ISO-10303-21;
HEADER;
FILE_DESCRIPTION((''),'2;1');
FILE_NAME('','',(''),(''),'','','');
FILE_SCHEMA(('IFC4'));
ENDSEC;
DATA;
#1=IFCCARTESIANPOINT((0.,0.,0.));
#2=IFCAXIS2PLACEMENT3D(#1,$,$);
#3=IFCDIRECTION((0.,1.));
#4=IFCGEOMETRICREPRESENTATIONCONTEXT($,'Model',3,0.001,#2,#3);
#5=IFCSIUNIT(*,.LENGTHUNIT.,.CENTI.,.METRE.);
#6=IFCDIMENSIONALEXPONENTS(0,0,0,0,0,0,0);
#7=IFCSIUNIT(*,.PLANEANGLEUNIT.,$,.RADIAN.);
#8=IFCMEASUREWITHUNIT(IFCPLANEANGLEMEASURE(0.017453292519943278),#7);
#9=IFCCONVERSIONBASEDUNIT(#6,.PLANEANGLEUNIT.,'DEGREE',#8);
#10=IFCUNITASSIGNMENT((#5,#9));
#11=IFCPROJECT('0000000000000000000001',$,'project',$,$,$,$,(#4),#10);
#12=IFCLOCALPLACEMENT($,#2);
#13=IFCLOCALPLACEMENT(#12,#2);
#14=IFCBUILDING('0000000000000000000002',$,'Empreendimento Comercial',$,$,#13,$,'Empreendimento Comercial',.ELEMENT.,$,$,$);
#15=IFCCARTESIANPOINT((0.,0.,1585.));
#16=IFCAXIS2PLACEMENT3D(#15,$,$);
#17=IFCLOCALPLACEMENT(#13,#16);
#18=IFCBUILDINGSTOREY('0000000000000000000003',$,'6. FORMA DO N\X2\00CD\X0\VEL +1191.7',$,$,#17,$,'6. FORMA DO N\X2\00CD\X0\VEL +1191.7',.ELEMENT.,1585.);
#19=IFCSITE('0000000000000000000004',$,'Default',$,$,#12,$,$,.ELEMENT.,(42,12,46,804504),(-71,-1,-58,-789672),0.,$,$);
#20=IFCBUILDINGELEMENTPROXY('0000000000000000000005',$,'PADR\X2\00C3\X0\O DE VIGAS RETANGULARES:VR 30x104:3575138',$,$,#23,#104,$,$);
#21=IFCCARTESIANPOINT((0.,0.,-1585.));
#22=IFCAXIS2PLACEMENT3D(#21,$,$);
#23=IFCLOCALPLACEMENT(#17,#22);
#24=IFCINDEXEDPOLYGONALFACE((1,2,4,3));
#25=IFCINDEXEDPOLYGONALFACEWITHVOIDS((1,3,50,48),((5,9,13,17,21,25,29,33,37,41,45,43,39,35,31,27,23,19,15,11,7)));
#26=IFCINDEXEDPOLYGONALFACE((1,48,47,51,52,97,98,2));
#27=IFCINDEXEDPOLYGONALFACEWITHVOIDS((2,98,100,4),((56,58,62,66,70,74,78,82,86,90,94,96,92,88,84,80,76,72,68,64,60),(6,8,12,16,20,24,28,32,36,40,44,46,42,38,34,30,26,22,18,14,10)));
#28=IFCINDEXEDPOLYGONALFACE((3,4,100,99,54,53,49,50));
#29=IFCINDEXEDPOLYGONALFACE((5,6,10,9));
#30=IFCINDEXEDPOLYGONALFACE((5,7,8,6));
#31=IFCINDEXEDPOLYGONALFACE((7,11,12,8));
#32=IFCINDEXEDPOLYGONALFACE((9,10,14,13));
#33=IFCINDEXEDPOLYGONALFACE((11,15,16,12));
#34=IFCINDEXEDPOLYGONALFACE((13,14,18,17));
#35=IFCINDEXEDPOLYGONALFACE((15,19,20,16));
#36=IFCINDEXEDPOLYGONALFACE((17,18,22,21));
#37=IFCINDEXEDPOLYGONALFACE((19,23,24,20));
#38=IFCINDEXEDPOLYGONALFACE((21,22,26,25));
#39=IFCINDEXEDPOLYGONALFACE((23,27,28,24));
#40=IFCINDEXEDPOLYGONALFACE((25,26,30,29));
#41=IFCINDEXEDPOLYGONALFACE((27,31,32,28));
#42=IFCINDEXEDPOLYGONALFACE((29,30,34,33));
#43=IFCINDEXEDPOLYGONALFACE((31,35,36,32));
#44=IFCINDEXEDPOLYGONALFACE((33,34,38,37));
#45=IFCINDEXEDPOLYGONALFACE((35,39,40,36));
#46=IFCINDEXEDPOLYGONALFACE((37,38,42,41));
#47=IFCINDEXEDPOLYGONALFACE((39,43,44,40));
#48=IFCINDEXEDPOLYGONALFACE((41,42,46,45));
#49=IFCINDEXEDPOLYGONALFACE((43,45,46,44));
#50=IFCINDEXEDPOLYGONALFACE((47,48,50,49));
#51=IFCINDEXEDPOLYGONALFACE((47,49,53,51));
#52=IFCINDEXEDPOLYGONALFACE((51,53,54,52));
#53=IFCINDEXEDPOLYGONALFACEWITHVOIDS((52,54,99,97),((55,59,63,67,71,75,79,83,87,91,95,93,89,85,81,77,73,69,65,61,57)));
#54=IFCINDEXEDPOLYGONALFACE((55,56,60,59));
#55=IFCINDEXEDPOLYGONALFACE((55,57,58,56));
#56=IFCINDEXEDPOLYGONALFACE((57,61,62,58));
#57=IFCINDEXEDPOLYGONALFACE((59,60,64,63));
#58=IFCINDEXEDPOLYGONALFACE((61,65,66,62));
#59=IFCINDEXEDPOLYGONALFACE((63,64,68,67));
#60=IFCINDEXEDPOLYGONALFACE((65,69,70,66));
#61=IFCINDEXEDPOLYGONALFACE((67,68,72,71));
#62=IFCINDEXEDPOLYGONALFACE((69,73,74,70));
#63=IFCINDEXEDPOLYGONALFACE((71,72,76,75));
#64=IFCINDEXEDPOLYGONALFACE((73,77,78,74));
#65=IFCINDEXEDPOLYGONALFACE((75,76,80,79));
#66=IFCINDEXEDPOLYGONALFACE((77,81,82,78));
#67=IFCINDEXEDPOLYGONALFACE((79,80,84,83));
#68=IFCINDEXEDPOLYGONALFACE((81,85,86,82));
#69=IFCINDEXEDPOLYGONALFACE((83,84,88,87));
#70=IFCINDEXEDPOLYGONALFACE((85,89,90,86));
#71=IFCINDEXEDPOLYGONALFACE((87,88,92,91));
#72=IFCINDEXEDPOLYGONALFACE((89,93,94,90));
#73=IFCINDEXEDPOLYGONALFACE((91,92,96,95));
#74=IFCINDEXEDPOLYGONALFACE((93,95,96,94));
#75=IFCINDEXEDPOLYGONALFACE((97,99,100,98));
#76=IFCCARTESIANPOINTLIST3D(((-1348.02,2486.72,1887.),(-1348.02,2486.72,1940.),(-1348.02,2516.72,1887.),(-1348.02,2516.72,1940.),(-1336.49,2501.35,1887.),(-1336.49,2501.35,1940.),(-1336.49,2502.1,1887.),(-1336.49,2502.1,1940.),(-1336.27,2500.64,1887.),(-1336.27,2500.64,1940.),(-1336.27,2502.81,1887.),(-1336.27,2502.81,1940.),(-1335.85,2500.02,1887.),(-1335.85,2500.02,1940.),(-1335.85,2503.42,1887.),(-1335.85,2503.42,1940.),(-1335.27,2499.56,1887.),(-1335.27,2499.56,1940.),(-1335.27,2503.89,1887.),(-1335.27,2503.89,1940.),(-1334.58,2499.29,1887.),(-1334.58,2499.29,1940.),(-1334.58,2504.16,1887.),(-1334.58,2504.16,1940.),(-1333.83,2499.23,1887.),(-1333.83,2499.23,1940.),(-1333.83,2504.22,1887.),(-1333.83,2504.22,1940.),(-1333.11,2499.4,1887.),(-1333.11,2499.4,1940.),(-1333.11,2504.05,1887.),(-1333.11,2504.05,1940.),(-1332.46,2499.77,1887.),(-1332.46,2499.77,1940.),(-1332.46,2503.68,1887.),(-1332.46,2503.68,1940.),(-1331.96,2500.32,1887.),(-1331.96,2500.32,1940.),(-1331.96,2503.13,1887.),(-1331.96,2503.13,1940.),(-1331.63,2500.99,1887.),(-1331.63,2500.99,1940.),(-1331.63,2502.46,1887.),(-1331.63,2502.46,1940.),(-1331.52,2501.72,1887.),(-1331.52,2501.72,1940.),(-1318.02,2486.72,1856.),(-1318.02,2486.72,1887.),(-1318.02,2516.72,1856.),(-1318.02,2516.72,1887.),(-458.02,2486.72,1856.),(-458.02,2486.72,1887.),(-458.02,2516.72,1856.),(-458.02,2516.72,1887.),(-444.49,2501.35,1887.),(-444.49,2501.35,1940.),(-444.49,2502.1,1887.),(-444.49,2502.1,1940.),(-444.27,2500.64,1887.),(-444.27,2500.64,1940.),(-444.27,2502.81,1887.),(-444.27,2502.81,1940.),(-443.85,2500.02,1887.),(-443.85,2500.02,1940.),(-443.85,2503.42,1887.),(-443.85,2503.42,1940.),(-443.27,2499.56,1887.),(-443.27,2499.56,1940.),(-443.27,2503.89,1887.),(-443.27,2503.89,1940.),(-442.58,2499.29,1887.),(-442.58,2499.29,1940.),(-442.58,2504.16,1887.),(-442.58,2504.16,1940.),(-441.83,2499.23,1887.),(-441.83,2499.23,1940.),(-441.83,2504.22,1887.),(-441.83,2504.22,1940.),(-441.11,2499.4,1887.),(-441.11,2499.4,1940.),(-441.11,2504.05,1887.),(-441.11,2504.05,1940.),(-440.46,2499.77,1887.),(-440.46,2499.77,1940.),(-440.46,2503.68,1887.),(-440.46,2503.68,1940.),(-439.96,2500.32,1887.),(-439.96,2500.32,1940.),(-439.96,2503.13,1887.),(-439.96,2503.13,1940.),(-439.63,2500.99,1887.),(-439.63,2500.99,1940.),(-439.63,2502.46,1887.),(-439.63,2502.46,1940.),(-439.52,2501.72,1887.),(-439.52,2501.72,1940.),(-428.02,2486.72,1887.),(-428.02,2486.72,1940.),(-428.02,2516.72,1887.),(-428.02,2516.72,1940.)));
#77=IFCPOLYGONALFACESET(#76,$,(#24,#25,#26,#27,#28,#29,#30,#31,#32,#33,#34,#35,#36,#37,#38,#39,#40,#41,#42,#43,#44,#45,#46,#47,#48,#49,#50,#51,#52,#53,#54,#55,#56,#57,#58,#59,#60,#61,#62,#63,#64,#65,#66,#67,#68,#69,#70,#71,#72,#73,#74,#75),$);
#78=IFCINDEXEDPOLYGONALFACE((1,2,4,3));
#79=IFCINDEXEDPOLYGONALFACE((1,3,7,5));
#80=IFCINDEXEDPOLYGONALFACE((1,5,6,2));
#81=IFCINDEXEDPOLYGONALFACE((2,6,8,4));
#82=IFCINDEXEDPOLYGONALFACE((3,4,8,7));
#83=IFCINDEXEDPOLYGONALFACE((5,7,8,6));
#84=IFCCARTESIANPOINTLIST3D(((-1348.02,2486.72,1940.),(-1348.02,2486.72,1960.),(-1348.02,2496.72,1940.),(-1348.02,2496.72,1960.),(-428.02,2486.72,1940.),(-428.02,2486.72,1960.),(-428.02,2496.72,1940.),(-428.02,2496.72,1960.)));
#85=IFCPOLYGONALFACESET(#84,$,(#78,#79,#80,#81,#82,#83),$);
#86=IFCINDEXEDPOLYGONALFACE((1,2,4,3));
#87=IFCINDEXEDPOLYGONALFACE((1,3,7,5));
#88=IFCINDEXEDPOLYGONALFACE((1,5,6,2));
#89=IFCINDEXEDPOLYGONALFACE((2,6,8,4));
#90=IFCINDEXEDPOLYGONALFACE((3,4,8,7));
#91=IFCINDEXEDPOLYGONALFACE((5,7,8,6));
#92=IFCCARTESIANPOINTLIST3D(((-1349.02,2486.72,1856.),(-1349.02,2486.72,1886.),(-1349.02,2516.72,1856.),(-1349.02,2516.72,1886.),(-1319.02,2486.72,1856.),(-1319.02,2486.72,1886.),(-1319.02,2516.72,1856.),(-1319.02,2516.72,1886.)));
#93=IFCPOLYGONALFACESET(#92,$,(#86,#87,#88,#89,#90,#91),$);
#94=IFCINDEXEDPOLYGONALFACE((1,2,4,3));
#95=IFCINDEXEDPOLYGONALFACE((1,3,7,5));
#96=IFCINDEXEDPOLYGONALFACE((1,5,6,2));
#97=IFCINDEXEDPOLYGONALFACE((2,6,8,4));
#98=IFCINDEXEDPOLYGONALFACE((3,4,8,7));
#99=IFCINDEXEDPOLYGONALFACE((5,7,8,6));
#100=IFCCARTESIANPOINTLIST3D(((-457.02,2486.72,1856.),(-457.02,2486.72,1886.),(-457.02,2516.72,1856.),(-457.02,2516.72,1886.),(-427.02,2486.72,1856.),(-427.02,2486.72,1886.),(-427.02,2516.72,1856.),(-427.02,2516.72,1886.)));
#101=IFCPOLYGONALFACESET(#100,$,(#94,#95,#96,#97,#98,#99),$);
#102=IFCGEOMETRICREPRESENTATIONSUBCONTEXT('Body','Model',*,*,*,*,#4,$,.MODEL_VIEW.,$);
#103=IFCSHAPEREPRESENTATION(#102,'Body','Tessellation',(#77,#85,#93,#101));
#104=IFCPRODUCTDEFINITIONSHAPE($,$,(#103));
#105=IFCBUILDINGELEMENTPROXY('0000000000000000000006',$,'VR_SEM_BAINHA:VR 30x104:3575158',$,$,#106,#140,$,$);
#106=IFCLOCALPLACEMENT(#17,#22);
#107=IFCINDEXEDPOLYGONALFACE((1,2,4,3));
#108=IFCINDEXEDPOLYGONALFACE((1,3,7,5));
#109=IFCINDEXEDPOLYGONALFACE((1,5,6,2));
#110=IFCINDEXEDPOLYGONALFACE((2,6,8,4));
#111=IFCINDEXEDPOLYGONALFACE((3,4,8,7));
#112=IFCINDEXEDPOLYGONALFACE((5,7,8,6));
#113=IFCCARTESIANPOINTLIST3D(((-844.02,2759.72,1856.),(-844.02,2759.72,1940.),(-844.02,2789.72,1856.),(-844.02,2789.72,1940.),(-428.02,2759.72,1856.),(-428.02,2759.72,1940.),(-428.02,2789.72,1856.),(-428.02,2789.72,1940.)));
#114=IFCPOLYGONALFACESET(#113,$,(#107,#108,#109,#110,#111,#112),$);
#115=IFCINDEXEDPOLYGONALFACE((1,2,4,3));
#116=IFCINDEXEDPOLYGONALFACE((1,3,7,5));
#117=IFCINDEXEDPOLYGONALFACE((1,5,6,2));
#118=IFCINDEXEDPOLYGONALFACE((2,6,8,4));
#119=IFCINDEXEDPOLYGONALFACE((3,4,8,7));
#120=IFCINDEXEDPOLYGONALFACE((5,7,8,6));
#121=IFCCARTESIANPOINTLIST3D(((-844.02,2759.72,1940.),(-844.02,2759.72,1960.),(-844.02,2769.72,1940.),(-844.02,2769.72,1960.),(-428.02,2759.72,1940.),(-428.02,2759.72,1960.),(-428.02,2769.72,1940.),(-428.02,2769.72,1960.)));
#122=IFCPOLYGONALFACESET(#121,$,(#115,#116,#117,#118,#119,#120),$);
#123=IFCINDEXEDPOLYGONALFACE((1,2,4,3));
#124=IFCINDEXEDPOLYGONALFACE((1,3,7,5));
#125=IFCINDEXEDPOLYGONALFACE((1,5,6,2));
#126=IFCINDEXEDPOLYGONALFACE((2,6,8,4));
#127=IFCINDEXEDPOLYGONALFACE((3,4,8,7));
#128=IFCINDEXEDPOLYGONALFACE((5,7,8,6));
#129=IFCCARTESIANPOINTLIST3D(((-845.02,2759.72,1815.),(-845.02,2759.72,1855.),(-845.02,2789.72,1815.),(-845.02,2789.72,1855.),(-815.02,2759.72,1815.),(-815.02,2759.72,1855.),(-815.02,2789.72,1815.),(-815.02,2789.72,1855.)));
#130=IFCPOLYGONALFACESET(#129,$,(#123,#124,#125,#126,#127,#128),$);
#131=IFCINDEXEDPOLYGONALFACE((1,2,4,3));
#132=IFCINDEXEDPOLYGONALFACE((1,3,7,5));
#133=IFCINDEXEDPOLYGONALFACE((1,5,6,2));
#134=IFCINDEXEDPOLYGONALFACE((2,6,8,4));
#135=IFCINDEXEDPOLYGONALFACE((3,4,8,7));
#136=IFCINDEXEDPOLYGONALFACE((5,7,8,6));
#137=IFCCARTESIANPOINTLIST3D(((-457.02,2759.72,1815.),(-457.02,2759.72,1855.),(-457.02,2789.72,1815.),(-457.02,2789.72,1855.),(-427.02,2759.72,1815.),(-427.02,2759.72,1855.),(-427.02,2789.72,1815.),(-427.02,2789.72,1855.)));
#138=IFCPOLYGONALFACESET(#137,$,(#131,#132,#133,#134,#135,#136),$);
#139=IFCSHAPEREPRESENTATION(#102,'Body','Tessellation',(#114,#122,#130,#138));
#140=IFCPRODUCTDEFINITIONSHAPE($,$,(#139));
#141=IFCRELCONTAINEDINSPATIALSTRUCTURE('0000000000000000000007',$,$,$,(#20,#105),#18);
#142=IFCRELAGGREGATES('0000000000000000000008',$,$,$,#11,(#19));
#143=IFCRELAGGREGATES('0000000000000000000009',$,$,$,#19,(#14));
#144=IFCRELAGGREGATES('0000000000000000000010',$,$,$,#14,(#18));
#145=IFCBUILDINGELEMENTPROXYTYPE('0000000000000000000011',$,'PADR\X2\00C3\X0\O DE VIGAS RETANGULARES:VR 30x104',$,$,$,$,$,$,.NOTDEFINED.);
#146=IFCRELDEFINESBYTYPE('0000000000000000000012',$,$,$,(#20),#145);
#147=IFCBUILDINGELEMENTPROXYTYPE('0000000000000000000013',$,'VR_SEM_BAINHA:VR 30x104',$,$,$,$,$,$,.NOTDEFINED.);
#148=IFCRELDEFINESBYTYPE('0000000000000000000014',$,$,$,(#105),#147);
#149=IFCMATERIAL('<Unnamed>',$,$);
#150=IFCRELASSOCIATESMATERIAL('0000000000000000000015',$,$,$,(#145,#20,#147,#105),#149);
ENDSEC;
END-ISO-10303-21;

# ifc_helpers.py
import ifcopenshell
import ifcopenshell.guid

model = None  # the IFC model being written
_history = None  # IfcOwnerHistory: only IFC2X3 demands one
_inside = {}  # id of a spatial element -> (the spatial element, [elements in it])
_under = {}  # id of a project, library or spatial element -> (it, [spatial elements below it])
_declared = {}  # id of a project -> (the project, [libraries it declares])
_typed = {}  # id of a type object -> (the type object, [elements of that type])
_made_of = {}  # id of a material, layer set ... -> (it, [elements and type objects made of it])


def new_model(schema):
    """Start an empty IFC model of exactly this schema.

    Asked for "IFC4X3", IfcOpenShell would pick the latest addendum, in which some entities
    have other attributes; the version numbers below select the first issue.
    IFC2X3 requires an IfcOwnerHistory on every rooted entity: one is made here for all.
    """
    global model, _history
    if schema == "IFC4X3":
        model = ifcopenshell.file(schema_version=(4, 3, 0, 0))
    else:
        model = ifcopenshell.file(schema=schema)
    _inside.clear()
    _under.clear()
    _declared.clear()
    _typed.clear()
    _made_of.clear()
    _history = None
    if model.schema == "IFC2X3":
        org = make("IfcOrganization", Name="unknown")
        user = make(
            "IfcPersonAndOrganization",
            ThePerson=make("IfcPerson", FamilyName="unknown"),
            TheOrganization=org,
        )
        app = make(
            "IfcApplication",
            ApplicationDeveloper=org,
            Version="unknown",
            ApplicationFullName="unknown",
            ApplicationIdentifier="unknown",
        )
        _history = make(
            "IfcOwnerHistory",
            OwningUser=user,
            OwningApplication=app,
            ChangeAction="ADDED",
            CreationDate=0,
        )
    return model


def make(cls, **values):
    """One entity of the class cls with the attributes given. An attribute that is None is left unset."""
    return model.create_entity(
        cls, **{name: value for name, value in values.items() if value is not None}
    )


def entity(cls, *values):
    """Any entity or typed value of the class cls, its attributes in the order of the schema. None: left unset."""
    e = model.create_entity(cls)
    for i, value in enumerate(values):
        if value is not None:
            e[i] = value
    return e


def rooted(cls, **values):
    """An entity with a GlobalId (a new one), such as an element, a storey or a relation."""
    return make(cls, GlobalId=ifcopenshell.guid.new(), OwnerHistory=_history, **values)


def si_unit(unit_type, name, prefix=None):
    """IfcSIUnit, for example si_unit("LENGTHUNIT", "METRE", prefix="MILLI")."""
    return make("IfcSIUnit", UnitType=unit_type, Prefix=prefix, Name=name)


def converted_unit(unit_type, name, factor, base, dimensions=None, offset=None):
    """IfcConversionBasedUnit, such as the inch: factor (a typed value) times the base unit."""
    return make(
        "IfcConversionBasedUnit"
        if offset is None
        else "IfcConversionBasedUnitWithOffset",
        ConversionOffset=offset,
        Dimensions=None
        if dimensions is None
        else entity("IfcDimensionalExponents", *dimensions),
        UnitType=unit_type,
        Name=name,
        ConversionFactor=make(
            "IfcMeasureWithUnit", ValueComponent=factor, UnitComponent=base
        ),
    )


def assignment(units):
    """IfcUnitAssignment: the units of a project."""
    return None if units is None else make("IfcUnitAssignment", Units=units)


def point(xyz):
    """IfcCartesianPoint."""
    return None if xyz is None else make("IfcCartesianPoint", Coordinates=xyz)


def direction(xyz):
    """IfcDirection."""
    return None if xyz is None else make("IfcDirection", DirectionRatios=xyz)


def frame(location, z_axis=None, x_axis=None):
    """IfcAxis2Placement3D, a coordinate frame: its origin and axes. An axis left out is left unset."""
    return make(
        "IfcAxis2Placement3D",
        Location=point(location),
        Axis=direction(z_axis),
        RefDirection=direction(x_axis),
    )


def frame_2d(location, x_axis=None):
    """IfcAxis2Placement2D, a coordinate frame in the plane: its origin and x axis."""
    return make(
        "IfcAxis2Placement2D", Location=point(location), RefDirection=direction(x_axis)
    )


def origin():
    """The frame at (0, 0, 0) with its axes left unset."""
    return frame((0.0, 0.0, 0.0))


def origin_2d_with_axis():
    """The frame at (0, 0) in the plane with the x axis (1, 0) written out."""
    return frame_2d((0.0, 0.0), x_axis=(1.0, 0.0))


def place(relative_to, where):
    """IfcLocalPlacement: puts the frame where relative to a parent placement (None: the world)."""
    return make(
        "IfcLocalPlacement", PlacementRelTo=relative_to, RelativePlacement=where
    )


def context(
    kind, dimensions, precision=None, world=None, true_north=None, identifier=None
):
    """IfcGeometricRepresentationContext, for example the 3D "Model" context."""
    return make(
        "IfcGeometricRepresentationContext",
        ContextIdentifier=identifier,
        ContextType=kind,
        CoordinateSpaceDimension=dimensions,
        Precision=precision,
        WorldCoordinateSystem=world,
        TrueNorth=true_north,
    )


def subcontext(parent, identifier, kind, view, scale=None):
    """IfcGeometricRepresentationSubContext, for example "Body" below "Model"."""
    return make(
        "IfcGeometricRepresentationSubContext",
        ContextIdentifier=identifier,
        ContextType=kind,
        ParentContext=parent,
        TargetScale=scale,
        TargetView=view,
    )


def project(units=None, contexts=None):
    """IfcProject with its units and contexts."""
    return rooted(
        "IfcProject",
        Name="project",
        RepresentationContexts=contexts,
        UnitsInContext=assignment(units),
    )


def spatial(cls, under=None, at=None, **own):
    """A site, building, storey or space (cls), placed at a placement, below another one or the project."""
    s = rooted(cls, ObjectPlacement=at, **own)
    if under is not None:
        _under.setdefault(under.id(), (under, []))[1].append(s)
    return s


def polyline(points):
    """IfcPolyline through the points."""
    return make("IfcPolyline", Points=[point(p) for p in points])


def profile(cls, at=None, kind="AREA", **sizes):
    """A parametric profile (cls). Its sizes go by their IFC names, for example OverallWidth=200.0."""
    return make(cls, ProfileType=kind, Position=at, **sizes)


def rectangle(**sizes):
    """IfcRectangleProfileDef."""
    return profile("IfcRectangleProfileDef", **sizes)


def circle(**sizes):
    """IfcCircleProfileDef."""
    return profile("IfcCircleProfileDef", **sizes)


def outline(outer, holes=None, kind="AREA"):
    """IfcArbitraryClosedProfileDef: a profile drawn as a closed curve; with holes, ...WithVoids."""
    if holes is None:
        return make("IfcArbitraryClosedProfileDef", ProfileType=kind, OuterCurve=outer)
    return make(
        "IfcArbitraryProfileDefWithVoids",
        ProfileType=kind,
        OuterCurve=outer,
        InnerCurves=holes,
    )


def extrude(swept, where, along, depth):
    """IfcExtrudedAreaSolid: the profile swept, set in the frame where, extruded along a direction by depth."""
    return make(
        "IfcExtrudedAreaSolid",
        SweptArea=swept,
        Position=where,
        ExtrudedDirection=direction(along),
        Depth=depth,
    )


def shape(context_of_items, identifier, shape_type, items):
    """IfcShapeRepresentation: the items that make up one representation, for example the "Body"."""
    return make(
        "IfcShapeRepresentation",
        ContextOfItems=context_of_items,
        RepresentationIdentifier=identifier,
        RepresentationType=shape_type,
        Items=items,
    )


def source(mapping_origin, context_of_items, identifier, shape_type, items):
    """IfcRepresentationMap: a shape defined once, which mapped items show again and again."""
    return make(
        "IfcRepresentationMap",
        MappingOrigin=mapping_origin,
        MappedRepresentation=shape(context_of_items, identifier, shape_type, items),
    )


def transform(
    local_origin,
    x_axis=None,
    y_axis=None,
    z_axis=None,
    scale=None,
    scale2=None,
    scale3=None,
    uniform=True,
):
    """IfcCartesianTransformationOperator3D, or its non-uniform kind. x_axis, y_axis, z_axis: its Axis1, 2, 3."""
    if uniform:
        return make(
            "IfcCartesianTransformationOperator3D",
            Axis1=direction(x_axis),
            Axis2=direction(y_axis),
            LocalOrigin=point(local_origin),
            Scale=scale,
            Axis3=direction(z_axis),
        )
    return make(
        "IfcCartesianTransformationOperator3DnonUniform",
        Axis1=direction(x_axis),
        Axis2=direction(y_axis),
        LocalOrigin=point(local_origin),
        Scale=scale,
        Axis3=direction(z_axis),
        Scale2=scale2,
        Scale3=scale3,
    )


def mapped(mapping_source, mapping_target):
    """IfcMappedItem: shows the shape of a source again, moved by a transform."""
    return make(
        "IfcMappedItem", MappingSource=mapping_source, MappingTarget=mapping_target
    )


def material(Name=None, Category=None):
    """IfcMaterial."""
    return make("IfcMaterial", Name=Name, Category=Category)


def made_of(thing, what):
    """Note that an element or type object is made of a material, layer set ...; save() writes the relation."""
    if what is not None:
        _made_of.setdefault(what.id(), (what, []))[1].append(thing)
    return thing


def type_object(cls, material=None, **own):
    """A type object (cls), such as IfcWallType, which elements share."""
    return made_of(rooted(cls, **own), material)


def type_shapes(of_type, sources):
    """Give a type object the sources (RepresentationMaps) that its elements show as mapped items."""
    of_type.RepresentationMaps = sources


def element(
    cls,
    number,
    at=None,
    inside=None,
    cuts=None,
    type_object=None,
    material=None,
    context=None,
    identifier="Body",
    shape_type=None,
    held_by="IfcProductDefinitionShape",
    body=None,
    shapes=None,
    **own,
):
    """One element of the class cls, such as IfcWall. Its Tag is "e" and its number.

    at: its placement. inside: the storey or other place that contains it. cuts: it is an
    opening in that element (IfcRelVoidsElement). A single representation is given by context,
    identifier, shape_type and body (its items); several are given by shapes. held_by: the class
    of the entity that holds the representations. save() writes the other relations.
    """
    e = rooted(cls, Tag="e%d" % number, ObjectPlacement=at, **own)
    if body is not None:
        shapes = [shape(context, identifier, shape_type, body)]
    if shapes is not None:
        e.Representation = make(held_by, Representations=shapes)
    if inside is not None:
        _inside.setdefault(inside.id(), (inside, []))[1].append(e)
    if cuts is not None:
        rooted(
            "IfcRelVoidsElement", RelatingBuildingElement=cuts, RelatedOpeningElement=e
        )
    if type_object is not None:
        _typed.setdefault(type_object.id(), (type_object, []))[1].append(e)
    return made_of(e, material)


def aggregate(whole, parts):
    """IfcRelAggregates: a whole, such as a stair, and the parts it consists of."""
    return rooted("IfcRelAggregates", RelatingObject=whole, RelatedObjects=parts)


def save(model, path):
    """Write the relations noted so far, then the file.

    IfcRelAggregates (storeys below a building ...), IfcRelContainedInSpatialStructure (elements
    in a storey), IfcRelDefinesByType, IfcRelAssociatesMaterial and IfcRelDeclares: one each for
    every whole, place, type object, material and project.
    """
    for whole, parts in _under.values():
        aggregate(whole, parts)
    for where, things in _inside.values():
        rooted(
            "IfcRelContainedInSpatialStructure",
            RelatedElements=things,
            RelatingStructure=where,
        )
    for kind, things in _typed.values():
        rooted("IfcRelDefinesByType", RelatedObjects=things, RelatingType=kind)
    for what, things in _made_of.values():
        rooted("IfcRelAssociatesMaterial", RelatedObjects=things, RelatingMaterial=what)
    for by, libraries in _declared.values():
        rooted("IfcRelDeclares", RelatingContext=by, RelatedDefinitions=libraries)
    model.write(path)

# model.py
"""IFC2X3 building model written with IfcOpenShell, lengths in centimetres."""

from ifc_helpers import new_model, entity, si_unit, converted_unit, direction, frame, frame_2d, origin, origin_2d_with_axis, place, context, subcontext, project, spatial, polyline, rectangle, circle, outline, extrude, source, transform, mapped, material, type_object, type_shapes, element, save


model = new_model("IFC2X3")

# Units and contexts
model_context = context("Model", 3, precision=0.001, world=origin(), true_north=direction((0.0, 1.0)))
body_context = subcontext(model_context, "Body", "Model", "MODEL_VIEW")
ifc_project = project(units=[si_unit("LENGTHUNIT", "METRE", prefix="CENTI"), converted_unit("PLANEANGLEUNIT", "DEGREE", entity("IfcPlaneAngleMeasure", 0.017453292519943278), si_unit("PLANEANGLEUNIT", "RADIAN"), dimensions=[0, 0, 0, 0, 0, 0, 0])], contexts=[model_context])

# Site, building, storey
site_placement = place(None, origin())
site = spatial("IfcSite", under=ifc_project, at=site_placement, Name="Default", CompositionType="ELEMENT", RefLatitude=(42, 12, 46, 804504), RefLongitude=(-71, -1, -58, -789672), RefElevation=0.0)
building_placement = place(site_placement, origin())
building = spatial("IfcBuilding", under=site, at=building_placement, Name="Empreendimento Comercial", LongName="Empreendimento Comercial", CompositionType="ELEMENT")
storey_placement = place(building_placement, frame((0.0, 0.0, 1585.0)))
storey = spatial("IfcBuildingStorey", under=building, at=storey_placement, Name="6. FORMA DO NÍVEL +1191.7", LongName="6. FORMA DO NÍVEL +1191.7", CompositionType="ELEMENT", Elevation=1585.0)

# Building element proxy, openings
ifc_material = material(Name="<Unnamed>")
building_element_proxy_type_1 = type_object("IfcBuildingElementProxyType", Name="PADRÃO DE VIGAS RETANGULARES:VR 30x104", PredefinedType="NOTDEFINED", material=ifc_material)
shared_shape_1 = source(origin(), body_context, "Body", "SweptSolid", [
    extrude(outline(polyline([(-460.0, -47.5), (460.0, -47.5), (460.0, 5.5), (430.0, 5.5), (430.0, 36.5), (-430.0, 36.5), (-430.0, 5.5), (-460.0, 5.5), (-460.0, -47.5)])), frame((-888.02, 2486.72, 1892.5), z_axis=(0.0, 1.0, 0.0), x_axis=(1.0, 0.0, 0.0)), (0.0, 0.0, 1.0), 30.0),
    extrude(rectangle(XDim=10.0, YDim=920.0, at=frame_2d((0.0, 0.0), x_axis=(1.0, 0.0))), frame((-888.02, 2491.72, 1940.0), z_axis=(0.0, 0.0, 1.0), x_axis=(0.0, 1.0, 0.0)), (0.0, 0.0, 1.0), 20.0),
    extrude(rectangle(XDim=30.0, YDim=30.0, at=frame_2d((0.0, 0.0), x_axis=(1.0, 0.0))), frame((-1334.02, 2501.72, 1856.0), z_axis=(0.0, 0.0, 1.0), x_axis=(-1.0, 0.0, 0.0)), (0.0, 0.0, 1.0), 30.0),
    extrude(rectangle(XDim=30.0, YDim=30.0, at=origin_2d_with_axis()), frame((-442.02, 2501.72, 1856.0), z_axis=(0.0, 0.0, 1.0), x_axis=(-1.0, 0.0, 0.0)), (0.0, 0.0, 1.0), 30.0),
])
type_shapes(building_element_proxy_type_1, [shared_shape_1])
proxy_1_placement = place(storey_placement, frame((0.0, 0.0, -1585.0)))
proxy_1 = element("IfcBuildingElementProxy", 1, at=proxy_1_placement, inside=storey, type_object=building_element_proxy_type_1, material=ifc_material, Name="PADRÃO DE VIGAS RETANGULARES:VR 30x104:3575138", context=body_context, shape_type="MappedRepresentation", body=[
    mapped(shared_shape_1, transform((0.0, 0.0, 0.0), scale=1.0)),
])
opening_1_placement = place(storey_placement, frame((0.0, 0.0, -1585.0)))
element("IfcOpeningElement", 2, at=opening_1_placement, cuts=proxy_1, ObjectType="Opening", context=body_context, shape_type="SweptSolid", body=[
    extrude(circle(Radius=2.5, at=origin_2d_with_axis()), frame((-442.02, 2501.72, 1940.0), z_axis=(0.0, 0.0, -1.0), x_axis=(1.0, 0.0, 0.0)), (0.0, 0.0, 1.0), 53.0),
])
opening_2_placement = place(storey_placement, frame((0.0, 0.0, -1585.0)))
element("IfcOpeningElement", 3, at=opening_2_placement, cuts=proxy_1, ObjectType="Opening", context=body_context, shape_type="SweptSolid", body=[
    extrude(circle(Radius=2.5, at=origin_2d_with_axis()), frame((-1334.02, 2501.72, 1940.0), z_axis=(0.0, 0.0, -1.0), x_axis=(1.0, 0.0, 0.0)), (0.0, 0.0, 1.0), 53.0),
])

# Building element proxy
building_element_proxy_type_2 = type_object("IfcBuildingElementProxyType", Name="VR_SEM_BAINHA:VR 30x104", PredefinedType="NOTDEFINED", material=ifc_material)
shared_shape_2 = source(origin(), body_context, "Body", "SweptSolid", [
    extrude(rectangle(XDim=30.0, YDim=416.0, at=frame_2d((5.0, 8.0), x_axis=(1.0, 0.0))), frame((-628.02, 2769.72, 1856.0), z_axis=(0.0, 0.0, 1.0), x_axis=(0.0, 1.0, 0.0)), (0.0, 0.0, 1.0), 84.0),
    extrude(rectangle(XDim=10.0, YDim=416.0, at=frame_2d((0.0, 0.0), x_axis=(1.0, 0.0))), frame((-636.02, 2764.72, 1940.0), z_axis=(0.0, 0.0, 1.0), x_axis=(0.0, 1.0, 0.0)), (0.0, 0.0, 1.0), 20.0),
    extrude(rectangle(XDim=30.0, YDim=30.0, at=frame_2d((0.0, 0.0), x_axis=(1.0, 0.0))), frame((-830.02, 2774.72, 1815.0), z_axis=(0.0, 0.0, 1.0), x_axis=(-1.0, 0.0, 0.0)), (0.0, 0.0, 1.0), 40.0),
    extrude(rectangle(XDim=30.0, YDim=30.0, at=frame_2d((0.0, 0.0), x_axis=(1.0, 0.0))), frame((-442.02, 2774.72, 1815.0), z_axis=(0.0, 0.0, 1.0), x_axis=(-1.0, 0.0, 0.0)), (0.0, 0.0, 1.0), 40.0),
])
type_shapes(building_element_proxy_type_2, [shared_shape_2])
proxy_2_placement = place(storey_placement, frame((0.0, 0.0, -1585.0)))
element("IfcBuildingElementProxy", 4, at=proxy_2_placement, inside=storey, type_object=building_element_proxy_type_2, material=ifc_material, Name="VR_SEM_BAINHA:VR 30x104:3575158", context=body_context, shape_type="MappedRepresentation", body=[
    mapped(shared_shape_2, transform((0.0, 0.0, 0.0), scale=1.0)),
])

save(model, "model.ifc")
